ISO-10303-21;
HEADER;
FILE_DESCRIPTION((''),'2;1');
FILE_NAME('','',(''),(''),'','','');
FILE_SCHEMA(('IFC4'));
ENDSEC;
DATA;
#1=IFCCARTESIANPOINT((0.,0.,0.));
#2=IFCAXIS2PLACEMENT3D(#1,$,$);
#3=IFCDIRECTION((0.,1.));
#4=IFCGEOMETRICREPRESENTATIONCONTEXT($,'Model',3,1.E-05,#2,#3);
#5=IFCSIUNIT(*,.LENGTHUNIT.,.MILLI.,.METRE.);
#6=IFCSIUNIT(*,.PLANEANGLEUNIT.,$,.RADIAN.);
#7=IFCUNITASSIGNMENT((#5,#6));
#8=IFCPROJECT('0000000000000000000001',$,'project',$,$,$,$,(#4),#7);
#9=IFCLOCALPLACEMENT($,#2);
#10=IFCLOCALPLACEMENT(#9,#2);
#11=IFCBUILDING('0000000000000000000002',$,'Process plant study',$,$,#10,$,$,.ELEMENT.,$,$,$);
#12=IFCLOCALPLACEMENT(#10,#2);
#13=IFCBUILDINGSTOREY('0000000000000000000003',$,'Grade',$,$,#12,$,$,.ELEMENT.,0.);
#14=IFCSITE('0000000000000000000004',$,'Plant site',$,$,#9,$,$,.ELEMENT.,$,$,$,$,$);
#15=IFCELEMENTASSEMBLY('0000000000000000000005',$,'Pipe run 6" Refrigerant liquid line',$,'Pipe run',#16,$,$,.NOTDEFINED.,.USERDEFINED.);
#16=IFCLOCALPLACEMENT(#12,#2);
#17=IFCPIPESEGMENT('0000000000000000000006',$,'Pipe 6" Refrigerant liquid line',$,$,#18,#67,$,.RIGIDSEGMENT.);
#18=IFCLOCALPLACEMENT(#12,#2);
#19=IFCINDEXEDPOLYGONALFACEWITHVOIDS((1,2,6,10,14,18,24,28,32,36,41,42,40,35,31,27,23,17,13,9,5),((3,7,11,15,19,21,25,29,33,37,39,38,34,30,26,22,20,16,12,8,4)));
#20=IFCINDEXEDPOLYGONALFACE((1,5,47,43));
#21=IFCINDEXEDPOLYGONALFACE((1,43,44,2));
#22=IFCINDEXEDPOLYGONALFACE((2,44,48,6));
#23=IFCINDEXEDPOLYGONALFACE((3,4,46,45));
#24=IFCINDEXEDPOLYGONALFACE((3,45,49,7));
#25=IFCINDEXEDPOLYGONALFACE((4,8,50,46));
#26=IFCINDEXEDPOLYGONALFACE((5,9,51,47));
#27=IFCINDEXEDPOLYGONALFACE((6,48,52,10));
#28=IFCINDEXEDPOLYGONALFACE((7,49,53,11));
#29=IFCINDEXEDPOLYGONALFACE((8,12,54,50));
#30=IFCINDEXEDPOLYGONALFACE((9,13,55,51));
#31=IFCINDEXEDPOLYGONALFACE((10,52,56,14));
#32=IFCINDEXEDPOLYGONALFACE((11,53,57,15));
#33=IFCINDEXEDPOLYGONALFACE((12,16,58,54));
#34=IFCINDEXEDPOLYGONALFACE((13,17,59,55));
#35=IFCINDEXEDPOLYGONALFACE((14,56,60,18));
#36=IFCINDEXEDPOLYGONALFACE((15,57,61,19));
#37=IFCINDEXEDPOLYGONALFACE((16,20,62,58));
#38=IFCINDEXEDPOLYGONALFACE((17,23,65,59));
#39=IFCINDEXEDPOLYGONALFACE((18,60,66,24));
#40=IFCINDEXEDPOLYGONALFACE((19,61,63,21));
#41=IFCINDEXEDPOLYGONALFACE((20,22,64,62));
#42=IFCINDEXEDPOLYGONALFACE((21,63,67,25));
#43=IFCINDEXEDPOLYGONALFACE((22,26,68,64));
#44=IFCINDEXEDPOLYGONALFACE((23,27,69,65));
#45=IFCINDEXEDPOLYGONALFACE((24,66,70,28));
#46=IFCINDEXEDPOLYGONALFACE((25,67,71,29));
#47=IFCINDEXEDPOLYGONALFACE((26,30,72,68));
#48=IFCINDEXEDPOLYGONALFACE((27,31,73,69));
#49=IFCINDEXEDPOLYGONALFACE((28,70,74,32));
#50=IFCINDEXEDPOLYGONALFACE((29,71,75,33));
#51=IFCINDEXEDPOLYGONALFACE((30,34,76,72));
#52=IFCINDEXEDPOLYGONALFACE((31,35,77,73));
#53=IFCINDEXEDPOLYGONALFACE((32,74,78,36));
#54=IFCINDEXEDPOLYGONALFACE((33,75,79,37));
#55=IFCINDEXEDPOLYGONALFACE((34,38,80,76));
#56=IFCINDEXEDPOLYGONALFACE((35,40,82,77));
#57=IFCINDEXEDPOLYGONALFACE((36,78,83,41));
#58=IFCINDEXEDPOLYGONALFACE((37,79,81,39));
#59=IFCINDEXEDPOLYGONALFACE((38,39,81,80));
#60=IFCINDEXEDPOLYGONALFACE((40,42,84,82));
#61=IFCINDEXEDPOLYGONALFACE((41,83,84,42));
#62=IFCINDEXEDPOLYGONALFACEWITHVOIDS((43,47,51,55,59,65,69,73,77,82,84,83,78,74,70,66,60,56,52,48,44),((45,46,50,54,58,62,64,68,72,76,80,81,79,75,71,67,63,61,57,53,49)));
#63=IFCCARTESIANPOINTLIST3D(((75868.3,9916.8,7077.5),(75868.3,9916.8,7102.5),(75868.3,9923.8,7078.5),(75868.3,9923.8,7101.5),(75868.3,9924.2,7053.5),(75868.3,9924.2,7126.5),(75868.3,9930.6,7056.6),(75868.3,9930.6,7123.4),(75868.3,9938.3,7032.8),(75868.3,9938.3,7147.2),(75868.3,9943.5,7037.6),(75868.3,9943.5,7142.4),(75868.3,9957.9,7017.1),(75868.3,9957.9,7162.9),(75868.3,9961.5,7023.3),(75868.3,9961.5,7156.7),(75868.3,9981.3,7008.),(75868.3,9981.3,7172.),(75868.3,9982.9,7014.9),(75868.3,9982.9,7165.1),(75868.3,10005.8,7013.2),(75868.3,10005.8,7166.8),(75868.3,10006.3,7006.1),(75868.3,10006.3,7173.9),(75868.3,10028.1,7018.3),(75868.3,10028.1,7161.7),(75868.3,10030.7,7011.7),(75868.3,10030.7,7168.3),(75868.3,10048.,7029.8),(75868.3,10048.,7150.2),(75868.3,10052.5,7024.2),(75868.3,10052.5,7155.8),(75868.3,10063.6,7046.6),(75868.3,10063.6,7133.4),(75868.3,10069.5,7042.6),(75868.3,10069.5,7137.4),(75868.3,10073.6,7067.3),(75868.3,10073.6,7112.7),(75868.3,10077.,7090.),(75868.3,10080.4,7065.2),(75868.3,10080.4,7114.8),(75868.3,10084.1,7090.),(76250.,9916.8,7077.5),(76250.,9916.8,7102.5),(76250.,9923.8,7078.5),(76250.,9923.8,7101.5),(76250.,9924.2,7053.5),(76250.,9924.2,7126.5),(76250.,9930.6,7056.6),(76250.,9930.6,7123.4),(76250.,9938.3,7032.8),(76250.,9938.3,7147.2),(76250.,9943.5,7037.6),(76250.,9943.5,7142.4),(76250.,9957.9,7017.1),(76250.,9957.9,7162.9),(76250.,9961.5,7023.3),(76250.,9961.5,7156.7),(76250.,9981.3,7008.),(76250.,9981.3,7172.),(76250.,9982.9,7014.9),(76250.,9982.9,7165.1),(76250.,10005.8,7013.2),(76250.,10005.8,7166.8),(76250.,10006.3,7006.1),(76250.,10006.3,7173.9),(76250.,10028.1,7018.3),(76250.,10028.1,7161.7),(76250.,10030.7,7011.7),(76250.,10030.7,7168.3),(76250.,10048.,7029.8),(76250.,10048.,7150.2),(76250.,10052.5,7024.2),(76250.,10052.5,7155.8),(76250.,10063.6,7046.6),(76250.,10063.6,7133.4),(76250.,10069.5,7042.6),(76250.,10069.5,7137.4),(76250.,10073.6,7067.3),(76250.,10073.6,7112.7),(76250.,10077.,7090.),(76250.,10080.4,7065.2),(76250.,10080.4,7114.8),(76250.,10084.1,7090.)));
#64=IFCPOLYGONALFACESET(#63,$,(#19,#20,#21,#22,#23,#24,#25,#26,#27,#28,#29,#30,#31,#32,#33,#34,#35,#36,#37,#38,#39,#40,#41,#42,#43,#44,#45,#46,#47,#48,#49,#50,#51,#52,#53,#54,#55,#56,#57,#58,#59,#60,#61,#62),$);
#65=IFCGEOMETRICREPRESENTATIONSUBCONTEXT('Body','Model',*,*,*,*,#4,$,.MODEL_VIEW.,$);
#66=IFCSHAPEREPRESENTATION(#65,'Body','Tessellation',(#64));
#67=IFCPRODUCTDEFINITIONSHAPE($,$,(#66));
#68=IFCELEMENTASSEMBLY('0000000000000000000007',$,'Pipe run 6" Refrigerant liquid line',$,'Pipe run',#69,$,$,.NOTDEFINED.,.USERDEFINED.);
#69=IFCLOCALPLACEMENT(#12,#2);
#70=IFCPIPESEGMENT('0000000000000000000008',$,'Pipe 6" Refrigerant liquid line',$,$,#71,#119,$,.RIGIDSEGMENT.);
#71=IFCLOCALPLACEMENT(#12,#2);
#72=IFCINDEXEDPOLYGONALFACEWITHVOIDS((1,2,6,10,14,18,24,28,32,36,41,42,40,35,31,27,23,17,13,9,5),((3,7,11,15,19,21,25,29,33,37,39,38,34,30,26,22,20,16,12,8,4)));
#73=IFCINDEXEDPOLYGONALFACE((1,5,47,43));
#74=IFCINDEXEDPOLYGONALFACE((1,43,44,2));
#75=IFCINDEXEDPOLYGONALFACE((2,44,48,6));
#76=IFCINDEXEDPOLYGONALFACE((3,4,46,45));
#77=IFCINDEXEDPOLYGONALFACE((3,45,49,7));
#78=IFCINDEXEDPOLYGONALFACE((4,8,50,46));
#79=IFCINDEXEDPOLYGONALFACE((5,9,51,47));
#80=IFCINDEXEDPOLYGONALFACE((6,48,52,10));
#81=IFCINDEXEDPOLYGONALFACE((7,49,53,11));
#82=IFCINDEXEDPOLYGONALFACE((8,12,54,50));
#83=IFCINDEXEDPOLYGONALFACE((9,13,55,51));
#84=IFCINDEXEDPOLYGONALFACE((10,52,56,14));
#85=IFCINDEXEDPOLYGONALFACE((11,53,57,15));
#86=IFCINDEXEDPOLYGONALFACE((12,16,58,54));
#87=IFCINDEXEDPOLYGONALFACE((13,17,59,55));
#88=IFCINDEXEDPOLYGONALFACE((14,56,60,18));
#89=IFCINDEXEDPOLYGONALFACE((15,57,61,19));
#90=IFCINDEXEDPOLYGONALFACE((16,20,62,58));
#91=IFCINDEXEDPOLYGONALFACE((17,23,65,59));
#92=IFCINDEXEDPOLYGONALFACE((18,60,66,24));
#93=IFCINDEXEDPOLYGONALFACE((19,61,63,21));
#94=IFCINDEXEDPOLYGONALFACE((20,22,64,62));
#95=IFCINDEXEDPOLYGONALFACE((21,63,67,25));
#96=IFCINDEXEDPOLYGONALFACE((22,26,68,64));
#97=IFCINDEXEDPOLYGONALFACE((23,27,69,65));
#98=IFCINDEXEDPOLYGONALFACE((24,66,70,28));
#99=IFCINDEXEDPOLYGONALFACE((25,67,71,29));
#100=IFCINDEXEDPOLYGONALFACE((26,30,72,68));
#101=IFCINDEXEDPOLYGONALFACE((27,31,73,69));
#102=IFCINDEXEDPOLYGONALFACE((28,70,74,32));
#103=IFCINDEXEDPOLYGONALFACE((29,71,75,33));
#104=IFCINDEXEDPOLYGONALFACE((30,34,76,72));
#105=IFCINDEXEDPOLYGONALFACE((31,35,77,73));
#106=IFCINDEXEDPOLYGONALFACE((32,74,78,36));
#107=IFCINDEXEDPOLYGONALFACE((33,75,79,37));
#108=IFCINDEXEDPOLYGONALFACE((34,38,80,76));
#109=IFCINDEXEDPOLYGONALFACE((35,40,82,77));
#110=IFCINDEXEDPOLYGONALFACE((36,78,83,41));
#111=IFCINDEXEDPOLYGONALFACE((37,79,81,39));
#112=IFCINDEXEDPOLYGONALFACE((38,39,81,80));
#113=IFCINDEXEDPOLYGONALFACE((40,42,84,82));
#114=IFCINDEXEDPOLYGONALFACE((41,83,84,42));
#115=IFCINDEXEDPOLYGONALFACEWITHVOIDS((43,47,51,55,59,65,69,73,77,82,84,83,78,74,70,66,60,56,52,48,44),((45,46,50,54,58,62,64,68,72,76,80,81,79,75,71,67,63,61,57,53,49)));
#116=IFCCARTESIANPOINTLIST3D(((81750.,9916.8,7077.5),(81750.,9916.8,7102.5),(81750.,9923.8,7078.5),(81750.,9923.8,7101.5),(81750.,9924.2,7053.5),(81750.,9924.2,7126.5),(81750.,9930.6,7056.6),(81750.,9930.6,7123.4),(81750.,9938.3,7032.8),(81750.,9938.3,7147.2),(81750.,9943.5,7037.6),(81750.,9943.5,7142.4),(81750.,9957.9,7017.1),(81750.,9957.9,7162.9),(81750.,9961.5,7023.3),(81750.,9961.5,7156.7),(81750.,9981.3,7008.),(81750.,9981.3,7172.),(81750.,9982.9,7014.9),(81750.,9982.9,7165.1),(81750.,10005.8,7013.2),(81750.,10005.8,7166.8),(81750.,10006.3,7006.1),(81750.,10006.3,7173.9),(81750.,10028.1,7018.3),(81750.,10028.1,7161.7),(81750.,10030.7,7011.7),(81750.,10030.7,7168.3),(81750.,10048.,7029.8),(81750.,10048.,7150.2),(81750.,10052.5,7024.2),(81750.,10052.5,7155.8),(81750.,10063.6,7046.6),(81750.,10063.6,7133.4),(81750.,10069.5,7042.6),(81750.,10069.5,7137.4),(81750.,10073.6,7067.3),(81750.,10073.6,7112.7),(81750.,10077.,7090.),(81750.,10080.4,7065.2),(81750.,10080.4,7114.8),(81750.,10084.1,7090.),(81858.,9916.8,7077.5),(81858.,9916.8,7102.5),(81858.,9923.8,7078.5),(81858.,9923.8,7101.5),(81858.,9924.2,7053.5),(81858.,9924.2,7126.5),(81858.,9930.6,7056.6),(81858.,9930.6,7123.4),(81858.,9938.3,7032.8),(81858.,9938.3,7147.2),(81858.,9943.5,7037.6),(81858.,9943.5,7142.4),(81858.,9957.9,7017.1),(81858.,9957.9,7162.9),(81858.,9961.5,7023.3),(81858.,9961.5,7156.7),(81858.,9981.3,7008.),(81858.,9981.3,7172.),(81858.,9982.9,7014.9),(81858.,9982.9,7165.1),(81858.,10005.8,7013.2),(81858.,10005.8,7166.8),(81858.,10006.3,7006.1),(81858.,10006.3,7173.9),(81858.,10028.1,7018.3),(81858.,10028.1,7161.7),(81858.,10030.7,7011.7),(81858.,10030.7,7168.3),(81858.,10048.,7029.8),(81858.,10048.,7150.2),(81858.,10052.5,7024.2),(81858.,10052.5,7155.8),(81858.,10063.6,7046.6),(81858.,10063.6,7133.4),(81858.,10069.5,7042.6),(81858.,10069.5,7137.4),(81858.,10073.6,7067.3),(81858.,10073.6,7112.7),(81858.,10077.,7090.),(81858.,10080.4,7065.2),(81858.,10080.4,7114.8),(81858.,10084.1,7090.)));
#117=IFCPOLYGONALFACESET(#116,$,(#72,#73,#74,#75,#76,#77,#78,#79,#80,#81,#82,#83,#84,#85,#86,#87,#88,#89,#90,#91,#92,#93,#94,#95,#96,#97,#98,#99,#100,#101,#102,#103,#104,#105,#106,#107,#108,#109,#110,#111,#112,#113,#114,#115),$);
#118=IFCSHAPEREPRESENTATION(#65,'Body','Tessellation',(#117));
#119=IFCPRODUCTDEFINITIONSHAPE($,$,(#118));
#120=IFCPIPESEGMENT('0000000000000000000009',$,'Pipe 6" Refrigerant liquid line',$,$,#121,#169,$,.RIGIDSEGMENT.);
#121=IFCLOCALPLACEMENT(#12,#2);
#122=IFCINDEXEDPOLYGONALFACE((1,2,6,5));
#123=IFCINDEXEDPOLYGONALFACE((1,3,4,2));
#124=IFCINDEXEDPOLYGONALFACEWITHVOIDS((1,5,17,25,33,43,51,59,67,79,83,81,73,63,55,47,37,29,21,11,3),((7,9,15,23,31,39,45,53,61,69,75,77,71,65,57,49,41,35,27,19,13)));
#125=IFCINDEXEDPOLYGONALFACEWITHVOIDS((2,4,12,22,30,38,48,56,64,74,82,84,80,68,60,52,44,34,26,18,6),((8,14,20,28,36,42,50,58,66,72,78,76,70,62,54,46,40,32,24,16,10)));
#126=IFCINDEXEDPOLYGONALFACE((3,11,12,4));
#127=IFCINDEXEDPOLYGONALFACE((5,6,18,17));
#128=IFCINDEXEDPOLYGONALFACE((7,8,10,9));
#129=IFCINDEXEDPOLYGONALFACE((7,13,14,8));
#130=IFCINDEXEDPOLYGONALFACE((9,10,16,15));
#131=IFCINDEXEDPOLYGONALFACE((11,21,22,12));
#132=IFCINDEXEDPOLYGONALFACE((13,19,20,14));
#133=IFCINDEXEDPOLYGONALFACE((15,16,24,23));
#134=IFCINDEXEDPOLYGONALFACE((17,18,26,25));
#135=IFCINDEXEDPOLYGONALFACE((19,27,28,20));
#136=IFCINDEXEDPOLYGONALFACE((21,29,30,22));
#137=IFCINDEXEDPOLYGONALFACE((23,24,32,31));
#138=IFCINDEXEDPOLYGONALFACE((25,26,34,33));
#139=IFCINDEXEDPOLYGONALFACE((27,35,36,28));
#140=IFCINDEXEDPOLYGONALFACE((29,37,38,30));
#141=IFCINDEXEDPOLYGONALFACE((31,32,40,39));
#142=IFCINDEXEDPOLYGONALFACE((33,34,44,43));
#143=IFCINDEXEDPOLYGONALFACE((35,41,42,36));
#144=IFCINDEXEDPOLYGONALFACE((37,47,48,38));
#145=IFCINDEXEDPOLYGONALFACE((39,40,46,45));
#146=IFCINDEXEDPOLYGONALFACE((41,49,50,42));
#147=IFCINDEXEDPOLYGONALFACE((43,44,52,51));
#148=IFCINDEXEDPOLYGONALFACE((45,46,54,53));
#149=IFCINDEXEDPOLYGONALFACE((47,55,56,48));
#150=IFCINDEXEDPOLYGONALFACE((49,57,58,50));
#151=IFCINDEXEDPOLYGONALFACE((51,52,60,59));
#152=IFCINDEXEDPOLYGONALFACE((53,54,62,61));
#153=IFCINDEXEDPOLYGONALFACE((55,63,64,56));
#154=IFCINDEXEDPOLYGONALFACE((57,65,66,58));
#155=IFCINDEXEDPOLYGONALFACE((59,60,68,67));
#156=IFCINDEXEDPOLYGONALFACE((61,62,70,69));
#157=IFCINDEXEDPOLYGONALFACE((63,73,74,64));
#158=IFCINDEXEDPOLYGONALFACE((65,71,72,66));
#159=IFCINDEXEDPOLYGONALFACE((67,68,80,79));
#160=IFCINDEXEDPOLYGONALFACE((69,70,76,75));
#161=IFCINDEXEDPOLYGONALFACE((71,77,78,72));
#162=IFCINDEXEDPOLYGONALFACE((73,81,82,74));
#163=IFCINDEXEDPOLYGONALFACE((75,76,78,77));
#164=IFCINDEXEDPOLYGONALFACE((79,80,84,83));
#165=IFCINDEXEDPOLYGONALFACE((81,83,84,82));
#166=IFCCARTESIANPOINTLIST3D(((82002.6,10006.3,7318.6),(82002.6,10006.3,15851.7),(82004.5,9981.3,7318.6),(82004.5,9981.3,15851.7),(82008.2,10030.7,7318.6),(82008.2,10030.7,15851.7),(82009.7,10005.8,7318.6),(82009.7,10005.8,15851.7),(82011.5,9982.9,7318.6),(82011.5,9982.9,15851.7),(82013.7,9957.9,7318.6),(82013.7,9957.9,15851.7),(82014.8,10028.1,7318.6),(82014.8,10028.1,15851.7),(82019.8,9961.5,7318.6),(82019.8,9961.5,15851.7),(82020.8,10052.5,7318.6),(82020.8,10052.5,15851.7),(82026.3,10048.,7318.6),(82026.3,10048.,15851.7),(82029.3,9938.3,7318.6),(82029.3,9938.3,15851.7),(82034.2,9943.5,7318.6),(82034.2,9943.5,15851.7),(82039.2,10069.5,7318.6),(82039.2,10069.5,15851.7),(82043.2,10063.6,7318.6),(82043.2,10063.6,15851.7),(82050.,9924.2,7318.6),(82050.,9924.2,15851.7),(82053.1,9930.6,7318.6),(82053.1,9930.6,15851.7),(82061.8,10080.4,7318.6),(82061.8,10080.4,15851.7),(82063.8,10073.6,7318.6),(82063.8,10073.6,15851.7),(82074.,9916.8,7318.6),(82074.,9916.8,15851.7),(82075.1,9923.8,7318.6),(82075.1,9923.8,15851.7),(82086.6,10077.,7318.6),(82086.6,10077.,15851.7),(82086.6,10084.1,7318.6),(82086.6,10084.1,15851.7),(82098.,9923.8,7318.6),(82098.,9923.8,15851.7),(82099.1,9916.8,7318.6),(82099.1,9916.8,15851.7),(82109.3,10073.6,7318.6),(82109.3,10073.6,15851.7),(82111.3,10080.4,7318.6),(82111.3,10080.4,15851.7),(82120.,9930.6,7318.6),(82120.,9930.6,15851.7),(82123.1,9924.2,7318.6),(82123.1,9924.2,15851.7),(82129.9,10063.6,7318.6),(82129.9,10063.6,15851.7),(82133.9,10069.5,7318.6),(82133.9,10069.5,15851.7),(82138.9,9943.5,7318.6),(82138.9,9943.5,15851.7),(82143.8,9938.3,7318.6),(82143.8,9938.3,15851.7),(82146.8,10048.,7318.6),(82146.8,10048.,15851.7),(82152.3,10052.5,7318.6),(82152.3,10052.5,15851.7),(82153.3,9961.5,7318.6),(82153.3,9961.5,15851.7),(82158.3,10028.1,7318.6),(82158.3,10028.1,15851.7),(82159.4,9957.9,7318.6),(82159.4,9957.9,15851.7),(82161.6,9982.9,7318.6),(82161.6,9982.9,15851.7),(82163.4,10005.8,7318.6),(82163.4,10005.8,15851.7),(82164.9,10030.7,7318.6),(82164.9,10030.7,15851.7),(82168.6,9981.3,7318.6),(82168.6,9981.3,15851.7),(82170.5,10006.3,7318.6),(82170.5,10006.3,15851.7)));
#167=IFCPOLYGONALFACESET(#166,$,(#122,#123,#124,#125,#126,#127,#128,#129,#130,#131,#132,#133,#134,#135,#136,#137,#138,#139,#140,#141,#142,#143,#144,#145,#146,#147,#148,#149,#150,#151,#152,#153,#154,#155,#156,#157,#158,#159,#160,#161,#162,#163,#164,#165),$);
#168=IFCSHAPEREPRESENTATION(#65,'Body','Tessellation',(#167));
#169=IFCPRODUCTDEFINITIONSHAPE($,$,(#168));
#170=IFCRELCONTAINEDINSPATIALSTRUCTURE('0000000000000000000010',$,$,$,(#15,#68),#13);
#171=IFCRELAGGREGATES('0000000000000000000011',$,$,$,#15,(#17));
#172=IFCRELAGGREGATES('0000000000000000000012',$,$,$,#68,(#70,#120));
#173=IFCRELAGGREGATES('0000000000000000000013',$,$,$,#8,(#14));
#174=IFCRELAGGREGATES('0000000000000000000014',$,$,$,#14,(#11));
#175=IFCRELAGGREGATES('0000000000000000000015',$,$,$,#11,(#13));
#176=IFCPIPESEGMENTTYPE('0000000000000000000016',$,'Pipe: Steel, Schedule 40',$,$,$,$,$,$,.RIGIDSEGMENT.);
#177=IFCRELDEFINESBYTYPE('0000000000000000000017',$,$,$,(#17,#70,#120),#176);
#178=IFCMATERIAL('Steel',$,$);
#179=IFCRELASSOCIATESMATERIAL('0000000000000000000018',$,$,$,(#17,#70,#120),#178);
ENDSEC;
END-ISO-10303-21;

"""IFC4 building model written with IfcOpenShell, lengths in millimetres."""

from ifc_helpers import new_model, si_unit, direction, frame, origin, origin_with_axes, origin_2d, place, context, subcontext, project, spatial, hollow_circle, extrude, material, type_object, element, aggregate, save


model = new_model("IFC4")

# Units and contexts
model_context = context("Model", 3, precision=1e-05, world=origin(), true_north=direction((0.0, 1.0)))
body_context = subcontext(model_context, "Body", "Model", "MODEL_VIEW")
ifc_project = project(units=[si_unit("LENGTHUNIT", "METRE", prefix="MILLI"), si_unit("PLANEANGLEUNIT", "RADIAN")], contexts=[model_context])

# Site, building, storey
site_placement = place(None, origin())
site = spatial("IfcSite", under=ifc_project, at=site_placement, Name="Plant site", CompositionType="ELEMENT")
building_placement = place(site_placement, origin())
building = spatial("IfcBuilding", under=site, at=building_placement, Name="Process plant study", CompositionType="ELEMENT")
storey_placement = place(building_placement, origin())
storey = spatial("IfcBuildingStorey", under=building, at=storey_placement, Name="Grade", CompositionType="ELEMENT", Elevation=0.0)

# Element assemblies, pipe segments
ifc_material = material(Name="Steel")
pipe_segment_type = type_object("IfcPipeSegmentType", Name="Pipe: Steel, Schedule 40", PredefinedType="RIGIDSEGMENT")
assembly_1_placement = place(storey_placement, origin_with_axes())
assembly_1 = element("IfcElementAssembly", 1, at=assembly_1_placement, inside=storey, Name="Pipe run 6\" Refrigerant liquid line", ObjectType="Pipe run", AssemblyPlace="NOTDEFINED", PredefinedType="USERDEFINED")
pipe_segment_1_placement = place(storey_placement, origin_with_axes())
pipe_segment_1 = element("IfcPipeSegment", 2, at=pipe_segment_1_placement, type_object=pipe_segment_type, material=ifc_material, Name="Pipe 6\" Refrigerant liquid line", PredefinedType="RIGIDSEGMENT", context=body_context, shape_type="SweptSolid", body=[
    extrude(hollow_circle(Radius=84.1, WallThickness=7.1, at=origin_2d()), frame((75868.3, 10000.0, 7090.0), z_axis=(1.0, 0.0, 0.0), x_axis=(0.0, 1.0, 0.0)), (0.0, 0.0, 1.0), 381.7),
])
assembly_2_placement = place(storey_placement, origin_with_axes())
assembly_2 = element("IfcElementAssembly", 3, at=assembly_2_placement, inside=storey, Name="Pipe run 6\" Refrigerant liquid line", ObjectType="Pipe run", AssemblyPlace="NOTDEFINED", PredefinedType="USERDEFINED")
pipe_segment_2_placement = place(storey_placement, origin_with_axes())
pipe_segment_2 = element("IfcPipeSegment", 4, at=pipe_segment_2_placement, type_object=pipe_segment_type, material=ifc_material, Name="Pipe 6\" Refrigerant liquid line", PredefinedType="RIGIDSEGMENT", context=body_context, shape_type="SweptSolid", body=[
    extrude(hollow_circle(Radius=84.1, WallThickness=7.1, at=origin_2d()), frame((81750.0, 10000.0, 7090.0), z_axis=(1.0, 0.0, 0.0), x_axis=(0.0, 1.0, 0.0)), (0.0, 0.0, 1.0), 108.0),
])
pipe_segment_3_placement = place(storey_placement, origin_with_axes())
pipe_segment_3 = element("IfcPipeSegment", 5, at=pipe_segment_3_placement, type_object=pipe_segment_type, material=ifc_material, Name="Pipe 6\" Refrigerant liquid line", PredefinedType="RIGIDSEGMENT", context=body_context, shape_type="SweptSolid", body=[
    extrude(hollow_circle(Radius=84.1, WallThickness=7.1, at=origin_2d()), frame((82086.6, 10000.0, 7318.6), z_axis=(0.0, 0.0, 1.0), x_axis=(0.0, 1.0, 0.0)), (0.0, 0.0, 1.0), 8533.1),
])

aggregate(assembly_1, [pipe_segment_1])
aggregate(assembly_2, [pipe_segment_2, pipe_segment_3])

save(model, "model.ifc")
